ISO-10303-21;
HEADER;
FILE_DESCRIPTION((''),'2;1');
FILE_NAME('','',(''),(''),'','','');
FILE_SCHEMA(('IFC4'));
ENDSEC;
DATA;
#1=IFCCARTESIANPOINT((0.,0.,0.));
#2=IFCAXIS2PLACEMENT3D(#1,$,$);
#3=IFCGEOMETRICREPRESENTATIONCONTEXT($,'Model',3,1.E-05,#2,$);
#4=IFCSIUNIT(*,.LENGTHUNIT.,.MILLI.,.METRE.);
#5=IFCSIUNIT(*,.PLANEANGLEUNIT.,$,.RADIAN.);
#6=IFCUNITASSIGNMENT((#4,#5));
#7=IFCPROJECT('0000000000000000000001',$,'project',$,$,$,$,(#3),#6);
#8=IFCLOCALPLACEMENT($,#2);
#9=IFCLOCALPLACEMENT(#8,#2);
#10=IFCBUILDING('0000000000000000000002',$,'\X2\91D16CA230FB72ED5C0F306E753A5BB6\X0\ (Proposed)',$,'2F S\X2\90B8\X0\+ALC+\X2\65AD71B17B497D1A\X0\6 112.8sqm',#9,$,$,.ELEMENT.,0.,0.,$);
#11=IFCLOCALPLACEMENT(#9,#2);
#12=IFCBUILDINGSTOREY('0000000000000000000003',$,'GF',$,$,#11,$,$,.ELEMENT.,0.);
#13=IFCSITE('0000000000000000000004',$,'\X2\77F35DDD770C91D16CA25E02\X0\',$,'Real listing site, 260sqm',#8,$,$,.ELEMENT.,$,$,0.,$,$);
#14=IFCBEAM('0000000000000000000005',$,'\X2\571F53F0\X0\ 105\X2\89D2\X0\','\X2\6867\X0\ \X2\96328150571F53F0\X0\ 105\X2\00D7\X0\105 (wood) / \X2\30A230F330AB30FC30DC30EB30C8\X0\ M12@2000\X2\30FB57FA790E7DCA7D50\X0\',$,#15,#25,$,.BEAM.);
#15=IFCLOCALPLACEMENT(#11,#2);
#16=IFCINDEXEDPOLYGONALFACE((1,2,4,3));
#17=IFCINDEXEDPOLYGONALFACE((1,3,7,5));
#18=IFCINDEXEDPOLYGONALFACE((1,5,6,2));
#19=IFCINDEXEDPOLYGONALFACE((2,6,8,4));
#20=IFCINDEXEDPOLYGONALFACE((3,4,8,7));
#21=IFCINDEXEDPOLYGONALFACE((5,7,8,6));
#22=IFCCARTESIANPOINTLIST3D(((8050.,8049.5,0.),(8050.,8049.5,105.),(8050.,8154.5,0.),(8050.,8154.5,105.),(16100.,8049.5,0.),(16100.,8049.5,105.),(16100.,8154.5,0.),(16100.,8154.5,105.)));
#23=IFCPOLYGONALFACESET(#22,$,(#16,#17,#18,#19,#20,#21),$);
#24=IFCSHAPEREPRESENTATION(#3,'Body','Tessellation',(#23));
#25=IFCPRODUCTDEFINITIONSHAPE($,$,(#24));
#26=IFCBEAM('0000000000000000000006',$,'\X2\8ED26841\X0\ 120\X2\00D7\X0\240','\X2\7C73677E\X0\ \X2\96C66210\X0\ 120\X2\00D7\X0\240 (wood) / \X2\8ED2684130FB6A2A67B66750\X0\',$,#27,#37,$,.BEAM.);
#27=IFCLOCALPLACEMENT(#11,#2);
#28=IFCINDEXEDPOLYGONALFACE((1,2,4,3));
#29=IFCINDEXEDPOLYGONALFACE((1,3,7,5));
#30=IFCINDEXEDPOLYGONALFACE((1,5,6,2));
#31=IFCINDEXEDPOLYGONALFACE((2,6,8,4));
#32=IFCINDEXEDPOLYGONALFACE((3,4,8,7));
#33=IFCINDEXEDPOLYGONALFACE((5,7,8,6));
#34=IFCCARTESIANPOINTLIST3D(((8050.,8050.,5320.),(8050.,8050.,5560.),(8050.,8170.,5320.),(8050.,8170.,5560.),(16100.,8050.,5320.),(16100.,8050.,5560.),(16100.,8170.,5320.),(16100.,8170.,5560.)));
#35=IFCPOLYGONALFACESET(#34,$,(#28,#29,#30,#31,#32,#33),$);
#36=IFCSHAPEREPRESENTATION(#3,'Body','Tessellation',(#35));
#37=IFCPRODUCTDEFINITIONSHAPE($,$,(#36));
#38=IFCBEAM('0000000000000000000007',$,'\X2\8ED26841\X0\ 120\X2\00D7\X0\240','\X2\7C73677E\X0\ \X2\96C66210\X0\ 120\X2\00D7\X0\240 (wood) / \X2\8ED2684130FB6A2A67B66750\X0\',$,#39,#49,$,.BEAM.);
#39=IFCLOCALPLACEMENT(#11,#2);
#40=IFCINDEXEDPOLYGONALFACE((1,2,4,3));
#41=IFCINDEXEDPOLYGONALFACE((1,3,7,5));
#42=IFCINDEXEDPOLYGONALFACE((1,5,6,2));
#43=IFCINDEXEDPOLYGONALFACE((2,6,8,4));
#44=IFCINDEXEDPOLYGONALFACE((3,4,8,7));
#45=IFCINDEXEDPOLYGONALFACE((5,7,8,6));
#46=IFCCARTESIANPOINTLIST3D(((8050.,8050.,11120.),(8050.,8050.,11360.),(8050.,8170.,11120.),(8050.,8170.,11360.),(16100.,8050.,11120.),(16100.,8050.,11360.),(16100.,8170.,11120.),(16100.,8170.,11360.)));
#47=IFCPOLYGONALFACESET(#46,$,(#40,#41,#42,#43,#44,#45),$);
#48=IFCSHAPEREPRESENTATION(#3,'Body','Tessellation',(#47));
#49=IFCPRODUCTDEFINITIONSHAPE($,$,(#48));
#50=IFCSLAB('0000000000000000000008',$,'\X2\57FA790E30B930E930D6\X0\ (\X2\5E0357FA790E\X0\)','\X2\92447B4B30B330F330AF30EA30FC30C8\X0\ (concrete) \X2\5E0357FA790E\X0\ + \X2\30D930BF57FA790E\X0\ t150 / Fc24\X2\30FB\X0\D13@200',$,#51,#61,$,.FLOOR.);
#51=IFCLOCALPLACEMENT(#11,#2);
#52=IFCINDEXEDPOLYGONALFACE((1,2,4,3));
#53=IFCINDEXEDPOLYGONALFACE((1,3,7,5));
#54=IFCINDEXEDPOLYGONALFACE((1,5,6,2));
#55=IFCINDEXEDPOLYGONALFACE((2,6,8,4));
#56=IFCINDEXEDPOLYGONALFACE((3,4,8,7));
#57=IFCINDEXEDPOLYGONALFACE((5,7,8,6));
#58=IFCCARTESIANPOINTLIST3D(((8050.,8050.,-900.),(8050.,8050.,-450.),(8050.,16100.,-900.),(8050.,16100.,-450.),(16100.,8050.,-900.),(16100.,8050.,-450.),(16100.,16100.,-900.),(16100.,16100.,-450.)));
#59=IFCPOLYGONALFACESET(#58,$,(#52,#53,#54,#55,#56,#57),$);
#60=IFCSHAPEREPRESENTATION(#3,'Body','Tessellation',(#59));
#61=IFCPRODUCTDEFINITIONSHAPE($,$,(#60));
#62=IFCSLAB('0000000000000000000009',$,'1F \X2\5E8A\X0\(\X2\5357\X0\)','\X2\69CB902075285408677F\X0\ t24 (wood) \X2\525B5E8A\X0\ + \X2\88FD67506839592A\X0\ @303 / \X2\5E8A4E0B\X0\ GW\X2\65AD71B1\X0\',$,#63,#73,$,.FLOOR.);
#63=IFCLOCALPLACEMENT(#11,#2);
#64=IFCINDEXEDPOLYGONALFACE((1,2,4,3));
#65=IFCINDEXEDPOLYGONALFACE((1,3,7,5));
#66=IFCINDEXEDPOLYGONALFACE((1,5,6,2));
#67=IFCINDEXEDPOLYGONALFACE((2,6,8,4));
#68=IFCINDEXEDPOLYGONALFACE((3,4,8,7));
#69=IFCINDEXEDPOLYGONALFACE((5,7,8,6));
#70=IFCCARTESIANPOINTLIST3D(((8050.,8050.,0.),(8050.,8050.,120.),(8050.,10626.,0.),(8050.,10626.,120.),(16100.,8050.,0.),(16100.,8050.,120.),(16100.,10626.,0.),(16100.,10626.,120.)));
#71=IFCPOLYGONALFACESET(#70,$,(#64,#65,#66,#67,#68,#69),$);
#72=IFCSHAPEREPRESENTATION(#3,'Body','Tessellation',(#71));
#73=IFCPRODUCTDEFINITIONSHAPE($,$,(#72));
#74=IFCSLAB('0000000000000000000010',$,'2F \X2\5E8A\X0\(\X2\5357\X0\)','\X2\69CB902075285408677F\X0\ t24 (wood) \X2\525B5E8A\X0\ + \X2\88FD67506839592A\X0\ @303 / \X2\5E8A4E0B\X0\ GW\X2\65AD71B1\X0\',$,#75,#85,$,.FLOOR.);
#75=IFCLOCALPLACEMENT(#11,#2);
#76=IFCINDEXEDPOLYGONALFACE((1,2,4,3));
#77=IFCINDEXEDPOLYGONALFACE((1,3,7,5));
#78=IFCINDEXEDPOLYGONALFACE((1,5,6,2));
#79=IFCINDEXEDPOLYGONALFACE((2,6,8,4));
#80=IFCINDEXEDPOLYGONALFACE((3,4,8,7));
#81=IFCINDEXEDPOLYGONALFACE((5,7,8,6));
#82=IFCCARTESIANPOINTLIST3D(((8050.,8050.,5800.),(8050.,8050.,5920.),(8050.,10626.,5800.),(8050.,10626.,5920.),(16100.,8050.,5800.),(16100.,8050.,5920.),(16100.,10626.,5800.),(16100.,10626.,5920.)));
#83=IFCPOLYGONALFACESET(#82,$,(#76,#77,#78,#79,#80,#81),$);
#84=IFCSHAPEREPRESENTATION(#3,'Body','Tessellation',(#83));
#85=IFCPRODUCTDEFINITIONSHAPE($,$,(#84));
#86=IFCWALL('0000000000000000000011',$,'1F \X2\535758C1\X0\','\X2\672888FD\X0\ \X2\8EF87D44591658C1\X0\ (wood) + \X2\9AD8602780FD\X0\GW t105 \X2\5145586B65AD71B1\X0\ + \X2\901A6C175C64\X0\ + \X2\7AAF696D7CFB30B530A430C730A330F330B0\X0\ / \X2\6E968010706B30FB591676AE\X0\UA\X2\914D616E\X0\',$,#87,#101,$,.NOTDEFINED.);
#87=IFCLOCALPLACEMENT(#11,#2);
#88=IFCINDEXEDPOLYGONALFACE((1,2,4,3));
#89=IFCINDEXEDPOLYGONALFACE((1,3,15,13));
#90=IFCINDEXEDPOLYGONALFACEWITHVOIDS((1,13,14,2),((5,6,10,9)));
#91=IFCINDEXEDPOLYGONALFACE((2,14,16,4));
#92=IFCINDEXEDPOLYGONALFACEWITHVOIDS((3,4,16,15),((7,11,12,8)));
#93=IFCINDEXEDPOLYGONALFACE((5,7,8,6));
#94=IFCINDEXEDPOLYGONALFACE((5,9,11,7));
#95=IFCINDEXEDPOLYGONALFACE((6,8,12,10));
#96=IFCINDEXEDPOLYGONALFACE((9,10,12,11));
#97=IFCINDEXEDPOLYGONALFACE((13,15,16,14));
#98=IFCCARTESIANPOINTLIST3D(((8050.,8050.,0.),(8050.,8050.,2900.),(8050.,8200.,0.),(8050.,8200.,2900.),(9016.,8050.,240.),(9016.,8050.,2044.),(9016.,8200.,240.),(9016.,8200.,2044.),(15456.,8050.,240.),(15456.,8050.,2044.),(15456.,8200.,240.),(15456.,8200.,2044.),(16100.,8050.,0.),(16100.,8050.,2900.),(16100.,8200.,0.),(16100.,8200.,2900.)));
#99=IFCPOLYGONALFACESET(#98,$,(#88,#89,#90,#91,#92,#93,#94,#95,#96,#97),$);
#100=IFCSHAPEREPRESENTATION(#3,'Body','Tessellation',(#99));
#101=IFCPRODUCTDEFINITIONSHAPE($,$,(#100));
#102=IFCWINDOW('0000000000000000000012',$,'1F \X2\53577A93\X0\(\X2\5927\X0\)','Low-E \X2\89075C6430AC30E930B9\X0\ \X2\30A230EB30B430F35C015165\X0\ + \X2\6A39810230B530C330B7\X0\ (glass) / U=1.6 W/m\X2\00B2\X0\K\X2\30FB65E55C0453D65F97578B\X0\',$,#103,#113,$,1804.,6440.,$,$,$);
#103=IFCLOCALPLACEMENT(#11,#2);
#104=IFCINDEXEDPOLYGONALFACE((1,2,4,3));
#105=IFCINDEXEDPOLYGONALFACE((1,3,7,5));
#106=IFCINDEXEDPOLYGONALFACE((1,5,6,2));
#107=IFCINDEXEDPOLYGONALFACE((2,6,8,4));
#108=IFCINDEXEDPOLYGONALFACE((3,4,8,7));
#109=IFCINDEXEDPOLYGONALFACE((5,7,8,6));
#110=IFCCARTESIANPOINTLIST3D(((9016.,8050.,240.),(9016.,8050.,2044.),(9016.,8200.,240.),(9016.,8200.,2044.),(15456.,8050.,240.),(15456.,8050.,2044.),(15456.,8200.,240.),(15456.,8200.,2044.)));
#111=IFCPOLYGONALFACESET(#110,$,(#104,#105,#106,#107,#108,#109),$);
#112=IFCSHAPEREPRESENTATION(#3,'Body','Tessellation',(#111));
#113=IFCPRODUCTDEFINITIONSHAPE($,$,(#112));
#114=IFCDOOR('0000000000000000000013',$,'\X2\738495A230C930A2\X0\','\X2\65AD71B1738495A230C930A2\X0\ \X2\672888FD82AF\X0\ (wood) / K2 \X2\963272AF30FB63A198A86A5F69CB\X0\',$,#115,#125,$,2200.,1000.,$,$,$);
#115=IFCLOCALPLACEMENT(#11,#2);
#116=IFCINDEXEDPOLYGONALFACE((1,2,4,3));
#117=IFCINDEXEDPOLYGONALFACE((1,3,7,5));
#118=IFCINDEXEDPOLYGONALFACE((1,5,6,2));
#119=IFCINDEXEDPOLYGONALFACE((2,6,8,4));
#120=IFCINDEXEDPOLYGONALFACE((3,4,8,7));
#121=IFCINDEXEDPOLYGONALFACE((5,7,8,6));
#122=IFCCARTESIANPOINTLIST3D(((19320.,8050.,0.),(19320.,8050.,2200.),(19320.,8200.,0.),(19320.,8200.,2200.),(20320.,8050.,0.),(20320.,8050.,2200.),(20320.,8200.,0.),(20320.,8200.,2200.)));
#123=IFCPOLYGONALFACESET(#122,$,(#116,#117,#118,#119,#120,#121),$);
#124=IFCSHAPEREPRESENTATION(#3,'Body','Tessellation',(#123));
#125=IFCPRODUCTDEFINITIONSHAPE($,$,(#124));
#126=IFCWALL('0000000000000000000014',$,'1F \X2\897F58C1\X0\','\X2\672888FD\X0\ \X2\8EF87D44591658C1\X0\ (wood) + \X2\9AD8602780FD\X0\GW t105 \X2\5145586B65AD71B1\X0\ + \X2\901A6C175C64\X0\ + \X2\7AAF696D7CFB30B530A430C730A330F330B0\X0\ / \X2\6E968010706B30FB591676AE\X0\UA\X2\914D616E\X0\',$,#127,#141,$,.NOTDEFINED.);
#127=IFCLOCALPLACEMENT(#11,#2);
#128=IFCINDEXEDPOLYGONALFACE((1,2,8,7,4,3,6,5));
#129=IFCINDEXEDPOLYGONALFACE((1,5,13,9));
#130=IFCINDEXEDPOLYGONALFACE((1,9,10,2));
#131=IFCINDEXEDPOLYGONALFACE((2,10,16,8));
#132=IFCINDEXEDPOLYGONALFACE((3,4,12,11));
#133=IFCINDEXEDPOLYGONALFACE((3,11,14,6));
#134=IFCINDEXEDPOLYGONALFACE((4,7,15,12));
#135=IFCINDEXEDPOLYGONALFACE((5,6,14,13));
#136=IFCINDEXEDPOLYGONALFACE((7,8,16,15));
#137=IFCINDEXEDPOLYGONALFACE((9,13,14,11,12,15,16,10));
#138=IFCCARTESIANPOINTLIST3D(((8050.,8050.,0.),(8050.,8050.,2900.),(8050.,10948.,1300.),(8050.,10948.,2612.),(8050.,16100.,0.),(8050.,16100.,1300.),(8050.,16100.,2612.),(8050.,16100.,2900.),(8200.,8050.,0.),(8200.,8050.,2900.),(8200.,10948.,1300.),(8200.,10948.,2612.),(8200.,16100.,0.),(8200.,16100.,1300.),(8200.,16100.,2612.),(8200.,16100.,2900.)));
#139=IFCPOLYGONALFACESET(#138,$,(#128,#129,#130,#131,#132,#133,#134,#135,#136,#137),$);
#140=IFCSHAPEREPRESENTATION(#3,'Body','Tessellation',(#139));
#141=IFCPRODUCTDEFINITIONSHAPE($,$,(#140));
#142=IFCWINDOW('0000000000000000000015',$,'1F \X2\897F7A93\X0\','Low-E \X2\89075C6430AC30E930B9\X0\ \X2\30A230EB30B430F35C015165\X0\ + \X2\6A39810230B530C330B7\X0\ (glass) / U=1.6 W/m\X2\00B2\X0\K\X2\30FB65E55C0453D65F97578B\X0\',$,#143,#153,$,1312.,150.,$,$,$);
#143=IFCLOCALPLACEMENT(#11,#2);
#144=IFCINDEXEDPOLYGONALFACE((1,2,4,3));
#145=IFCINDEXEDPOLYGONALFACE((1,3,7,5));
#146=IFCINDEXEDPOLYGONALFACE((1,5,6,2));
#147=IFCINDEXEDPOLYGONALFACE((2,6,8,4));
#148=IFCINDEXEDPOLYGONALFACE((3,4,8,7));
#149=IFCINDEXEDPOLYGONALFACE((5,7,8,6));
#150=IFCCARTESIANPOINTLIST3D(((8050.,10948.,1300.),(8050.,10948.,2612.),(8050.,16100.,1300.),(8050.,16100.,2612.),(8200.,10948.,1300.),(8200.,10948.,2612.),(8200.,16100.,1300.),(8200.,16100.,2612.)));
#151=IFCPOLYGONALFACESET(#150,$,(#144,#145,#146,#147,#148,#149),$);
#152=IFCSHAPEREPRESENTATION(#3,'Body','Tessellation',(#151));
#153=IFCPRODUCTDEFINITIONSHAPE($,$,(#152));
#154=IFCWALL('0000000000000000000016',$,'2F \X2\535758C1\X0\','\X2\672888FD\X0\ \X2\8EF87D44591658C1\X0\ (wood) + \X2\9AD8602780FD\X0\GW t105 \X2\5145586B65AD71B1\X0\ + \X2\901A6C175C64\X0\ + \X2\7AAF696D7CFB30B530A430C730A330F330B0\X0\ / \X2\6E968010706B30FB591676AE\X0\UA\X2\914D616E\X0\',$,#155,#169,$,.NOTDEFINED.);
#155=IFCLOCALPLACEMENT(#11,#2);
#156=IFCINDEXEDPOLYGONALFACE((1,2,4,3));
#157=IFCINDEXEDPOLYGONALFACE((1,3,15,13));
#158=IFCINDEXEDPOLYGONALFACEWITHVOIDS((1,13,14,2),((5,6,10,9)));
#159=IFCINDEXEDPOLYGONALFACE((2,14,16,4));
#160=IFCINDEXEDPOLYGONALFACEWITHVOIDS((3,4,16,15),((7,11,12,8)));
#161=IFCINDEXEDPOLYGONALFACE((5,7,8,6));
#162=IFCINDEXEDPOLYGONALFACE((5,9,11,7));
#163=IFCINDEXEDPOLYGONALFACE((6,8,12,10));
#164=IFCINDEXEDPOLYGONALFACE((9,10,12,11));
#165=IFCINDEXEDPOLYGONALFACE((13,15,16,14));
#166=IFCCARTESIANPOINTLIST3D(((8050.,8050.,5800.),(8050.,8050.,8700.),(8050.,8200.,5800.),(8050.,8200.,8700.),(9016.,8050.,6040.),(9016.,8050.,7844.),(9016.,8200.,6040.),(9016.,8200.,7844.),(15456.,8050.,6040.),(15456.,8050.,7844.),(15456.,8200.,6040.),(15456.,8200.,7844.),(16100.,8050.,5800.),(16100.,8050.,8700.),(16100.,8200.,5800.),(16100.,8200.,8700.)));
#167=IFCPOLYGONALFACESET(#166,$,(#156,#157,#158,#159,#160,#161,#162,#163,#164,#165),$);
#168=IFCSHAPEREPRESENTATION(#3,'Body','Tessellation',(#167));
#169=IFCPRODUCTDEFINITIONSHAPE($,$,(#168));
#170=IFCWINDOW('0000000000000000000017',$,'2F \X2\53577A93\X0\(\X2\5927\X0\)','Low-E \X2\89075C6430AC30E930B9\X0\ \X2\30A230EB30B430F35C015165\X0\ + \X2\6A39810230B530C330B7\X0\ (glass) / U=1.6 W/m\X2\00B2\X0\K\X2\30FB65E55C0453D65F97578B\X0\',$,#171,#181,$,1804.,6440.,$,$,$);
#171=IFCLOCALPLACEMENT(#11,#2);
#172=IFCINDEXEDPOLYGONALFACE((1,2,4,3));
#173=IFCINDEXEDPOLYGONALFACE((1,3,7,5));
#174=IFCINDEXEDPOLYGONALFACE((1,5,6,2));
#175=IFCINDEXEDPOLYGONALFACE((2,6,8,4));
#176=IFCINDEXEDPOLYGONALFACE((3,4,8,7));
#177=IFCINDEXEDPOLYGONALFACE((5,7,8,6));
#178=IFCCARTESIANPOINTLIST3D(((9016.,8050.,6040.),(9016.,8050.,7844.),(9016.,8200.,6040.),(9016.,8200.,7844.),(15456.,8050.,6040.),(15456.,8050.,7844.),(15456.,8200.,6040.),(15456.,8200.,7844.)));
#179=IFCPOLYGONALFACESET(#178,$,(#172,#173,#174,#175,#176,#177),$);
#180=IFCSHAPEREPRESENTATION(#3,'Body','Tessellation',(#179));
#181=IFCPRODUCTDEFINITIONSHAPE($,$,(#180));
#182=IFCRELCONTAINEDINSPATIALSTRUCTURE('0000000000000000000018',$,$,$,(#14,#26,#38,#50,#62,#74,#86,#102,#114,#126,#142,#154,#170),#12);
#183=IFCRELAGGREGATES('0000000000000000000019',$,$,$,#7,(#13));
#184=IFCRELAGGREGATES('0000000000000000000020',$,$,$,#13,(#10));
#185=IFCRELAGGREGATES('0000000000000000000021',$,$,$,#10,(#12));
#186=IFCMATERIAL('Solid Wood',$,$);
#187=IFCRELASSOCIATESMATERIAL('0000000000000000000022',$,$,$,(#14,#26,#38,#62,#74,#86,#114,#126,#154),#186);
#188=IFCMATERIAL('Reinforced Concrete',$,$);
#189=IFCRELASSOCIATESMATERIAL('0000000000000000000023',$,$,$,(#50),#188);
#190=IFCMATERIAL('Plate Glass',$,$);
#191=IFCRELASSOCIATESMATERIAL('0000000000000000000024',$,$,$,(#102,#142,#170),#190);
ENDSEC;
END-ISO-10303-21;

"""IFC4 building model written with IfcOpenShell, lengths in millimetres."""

from ifc_helpers import new_model, si_unit, frame, frame_2d, origin, place, context, project, spatial, rectangle, extrude, material, element, fill, save


model = new_model("IFC4")

# Units and contexts
model_context = context("Model", 3, precision=1e-05, world=origin())
ifc_project = project(units=[si_unit("LENGTHUNIT", "METRE", prefix="MILLI"), si_unit("PLANEANGLEUNIT", "RADIAN")], contexts=[model_context])

# Site, building, storey
site_placement = place(None, origin())
site = spatial("IfcSite", under=ifc_project, at=site_placement, Name="石川県金沢市", ObjectType="Real listing site, 260sqm", CompositionType="ELEMENT", RefElevation=0.0)
building_placement = place(site_placement, origin())
building = spatial("IfcBuilding", under=site, at=building_placement, Name="金沢・狭小の町家 (Proposed)", ObjectType="2F S邸+ALC+断熱等級6 112.8sqm", CompositionType="ELEMENT", ElevationOfRefHeight=0.0, ElevationOfTerrain=0.0)
storey_placement = place(building_placement, origin())
storey = spatial("IfcBuildingStorey", under=building, at=storey_placement, Name="GF", CompositionType="ELEMENT", Elevation=0.0)

# Shared definitions
ifc_material_1 = material(Name="Solid Wood")

# Beams
beam_1_placement = place(storey_placement, frame((4025.0, 4025.0, 0.0)))
element("IfcBeam", 1, at=beam_1_placement, inside=storey, material=ifc_material_1, Name="土台 105角", Description="桧 防腐土台 105×105 (wood) / アンカーボルト M12@2000・基礎緊結", PredefinedType="BEAM", context=model_context, shape_type="SweptSolid", body=[
    extrude(rectangle(XDim=8050.0, YDim=105.0, at=frame_2d((4025.0, 52.0))), frame((4025.0, 4025.0, 0.0)), (0.0, 0.0, 1.0), 105.0),
])
beam_2_placement = place(storey_placement, frame((4025.0, 4025.0, 2660.0)))
element("IfcBeam", 2, at=beam_2_placement, inside=storey, material=ifc_material_1, Name="軒桁 120×240", Description="米松 集成 120×240 (wood) / 軒桁・横架材", PredefinedType="BEAM", context=model_context, shape_type="SweptSolid", body=[
    extrude(rectangle(XDim=8050.0, YDim=120.0, at=frame_2d((4025.0, 60.0))), frame((4025.0, 4025.0, 2660.0)), (0.0, 0.0, 1.0), 240.0),
])
beam_3_placement = place(storey_placement, frame((4025.0, 4025.0, 5560.0)))
element("IfcBeam", 3, at=beam_3_placement, inside=storey, material=ifc_material_1, Name="軒桁 120×240", Description="米松 集成 120×240 (wood) / 軒桁・横架材", PredefinedType="BEAM", context=model_context, shape_type="SweptSolid", body=[
    extrude(rectangle(XDim=8050.0, YDim=120.0, at=frame_2d((4025.0, 60.0))), frame((4025.0, 4025.0, 5560.0)), (0.0, 0.0, 1.0), 240.0),
])

# Slabs
ifc_material_2 = material(Name="Reinforced Concrete")
slab_1_placement = place(storey_placement, frame((4025.0, 4025.0, -450.0)))
element("IfcSlab", 4, at=slab_1_placement, inside=storey, material=ifc_material_2, Name="基礎スラブ (布基礎)", Description="鉄筋コンクリート (concrete) 布基礎 + ベタ基礎 t150 / Fc24・D13@200", PredefinedType="FLOOR", context=model_context, shape_type="SweptSolid", body=[
    extrude(rectangle(XDim=8050.0, YDim=8050.0, at=frame_2d((4025.0, 4025.0))), frame((4025.0, 4025.0, -450.0)), (0.0, 0.0, 1.0), 450.0),
])
slab_2_placement = place(storey_placement, frame((4025.0, 4025.0, 0.0)))
element("IfcSlab", 5, at=slab_2_placement, inside=storey, material=ifc_material_1, Name="1F 床(南)", Description="構造用合板 t24 (wood) 剛床 + 製材根太 @303 / 床下 GW断熱", PredefinedType="FLOOR", context=model_context, shape_type="SweptSolid", body=[
    extrude(rectangle(XDim=8050.0, YDim=2576.0, at=frame_2d((4025.0, 1288.0))), frame((4025.0, 4025.0, 0.0)), (0.0, 0.0, 1.0), 120.0),
])
slab_3_placement = place(storey_placement, frame((4025.0, 4025.0, 2900.0)))
element("IfcSlab", 6, at=slab_3_placement, inside=storey, material=ifc_material_1, Name="2F 床(南)", Description="構造用合板 t24 (wood) 剛床 + 製材根太 @303 / 床下 GW断熱", PredefinedType="FLOOR", context=model_context, shape_type="SweptSolid", body=[
    extrude(rectangle(XDim=8050.0, YDim=2576.0, at=frame_2d((4025.0, 1288.0))), frame((4025.0, 4025.0, 2900.0)), (0.0, 0.0, 1.0), 120.0),
])

# Wall, openings, window, door
wall_1_placement = place(storey_placement, frame((4025.0, 4025.0, 0.0)))
wall_1 = element("IfcWall", 7, at=wall_1_placement, inside=storey, material=ifc_material_1, Name="1F 南壁", Description="木製 軸組外壁 (wood) + 高性能GW t105 充填断熱 + 通気層 + 窯業系サイディング / 準耐火・外皮UA配慮", PredefinedType="NOTDEFINED", context=model_context, shape_type="SweptSolid", body=[
    extrude(rectangle(XDim=8050.0, YDim=150.0, at=frame_2d((4025.0, 75.0))), frame((4025.0, 4025.0, 0.0)), (0.0, 0.0, 1.0), 2900.0),
])
opening_1_placement = place(storey_placement, frame((4508.0, 4025.0, 120.0)))
opening_1 = element("IfcOpeningElement", 8, at=opening_1_placement, cuts=wall_1, PredefinedType="NOTDEFINED", context=model_context, shape_type="SweptSolid", body=[
    extrude(rectangle(XDim=6440.0, YDim=150.0, at=frame_2d((3220.0, 75.0))), frame((4508.0, 4025.0, 120.0)), (0.0, 0.0, 1.0), 1804.0),
])
opening_2_placement = place(storey_placement, frame((9660.0, 4025.0, 0.0)))
opening_2 = element("IfcOpeningElement", 9, at=opening_2_placement, cuts=wall_1, PredefinedType="NOTDEFINED", context=model_context, shape_type="SweptSolid", body=[
    extrude(rectangle(XDim=1000.0, YDim=150.0, at=frame_2d((500.0, 75.0))), frame((9660.0, 4025.0, 0.0)), (0.0, 0.0, 1.0), 2200.0),
])
ifc_material_3 = material(Name="Plate Glass")
window_1_placement = place(storey_placement, frame((4508.0, 4025.0, 120.0)))
window_1 = element("IfcWindow", 10, at=window_1_placement, inside=storey, material=ifc_material_3, Name="1F 南窓(大)", Description="Low-E 複層ガラス アルゴン封入 + 樹脂サッシ (glass) / U=1.6 W/m²K・日射取得型", OverallHeight=1804.0, OverallWidth=6440.0, context=model_context, shape_type="SweptSolid", body=[
    extrude(rectangle(XDim=6440.0, YDim=150.0, at=frame_2d((3220.0, 75.0))), frame((4508.0, 4025.0, 120.0)), (0.0, 0.0, 1.0), 1804.0),
])
fill(opening_1, window_1)
door_placement = place(storey_placement, frame((9660.0, 4025.0, 0.0)))
door = element("IfcDoor", 11, at=door_placement, inside=storey, material=ifc_material_1, Name="玄関ドア", Description="断熱玄関ドア 木製芯 (wood) / K2 防犯・採風機構", OverallHeight=2200.0, OverallWidth=1000.0, context=model_context, shape_type="SweptSolid", body=[
    extrude(rectangle(XDim=1000.0, YDim=150.0, at=frame_2d((500.0, 75.0))), frame((9660.0, 4025.0, 0.0)), (0.0, 0.0, 1.0), 2200.0),
])
fill(opening_2, door)

# Walls, openings, windows
wall_2_placement = place(storey_placement, frame((4025.0, 4025.0, 0.0)))
wall_2 = element("IfcWall", 12, at=wall_2_placement, inside=storey, material=ifc_material_1, Name="1F 西壁", Description="木製 軸組外壁 (wood) + 高性能GW t105 充填断熱 + 通気層 + 窯業系サイディング / 準耐火・外皮UA配慮", PredefinedType="NOTDEFINED", context=model_context, shape_type="SweptSolid", body=[
    extrude(rectangle(XDim=150.0, YDim=8050.0, at=frame_2d((75.0, 4025.0))), frame((4025.0, 4025.0, 0.0)), (0.0, 0.0, 1.0), 2900.0),
])
opening_3_placement = place(storey_placement, frame((4025.0, 5474.0, 650.0)))
opening_3 = element("IfcOpeningElement", 13, at=opening_3_placement, cuts=wall_2, PredefinedType="NOTDEFINED", context=model_context, shape_type="SweptSolid", body=[
    extrude(rectangle(XDim=150.0, YDim=5152.0, at=frame_2d((75.0, 2576.0))), frame((4025.0, 5474.0, 650.0)), (0.0, 0.0, 1.0), 1312.0),
])
window_2_placement = place(storey_placement, frame((4025.0, 5474.0, 650.0)))
window_2 = element("IfcWindow", 14, at=window_2_placement, inside=storey, material=ifc_material_3, Name="1F 西窓", Description="Low-E 複層ガラス アルゴン封入 + 樹脂サッシ (glass) / U=1.6 W/m²K・日射取得型", OverallHeight=1312.0, OverallWidth=150.0, context=model_context, shape_type="SweptSolid", body=[
    extrude(rectangle(XDim=150.0, YDim=5152.0, at=frame_2d((75.0, 2576.0))), frame((4025.0, 5474.0, 650.0)), (0.0, 0.0, 1.0), 1312.0),
])
fill(opening_3, window_2)
wall_3_placement = place(storey_placement, frame((4025.0, 4025.0, 2900.0)))
wall_3 = element("IfcWall", 15, at=wall_3_placement, inside=storey, material=ifc_material_1, Name="2F 南壁", Description="木製 軸組外壁 (wood) + 高性能GW t105 充填断熱 + 通気層 + 窯業系サイディング / 準耐火・外皮UA配慮", PredefinedType="NOTDEFINED", context=model_context, shape_type="SweptSolid", body=[
    extrude(rectangle(XDim=8050.0, YDim=150.0, at=frame_2d((4025.0, 75.0))), frame((4025.0, 4025.0, 2900.0)), (0.0, 0.0, 1.0), 2900.0),
])
opening_4_placement = place(storey_placement, frame((4508.0, 4025.0, 3020.0)))
opening_4 = element("IfcOpeningElement", 16, at=opening_4_placement, cuts=wall_3, PredefinedType="NOTDEFINED", context=model_context, shape_type="SweptSolid", body=[
    extrude(rectangle(XDim=6440.0, YDim=150.0, at=frame_2d((3220.0, 75.0))), frame((4508.0, 4025.0, 3020.0)), (0.0, 0.0, 1.0), 1804.0),
])
window_3_placement = place(storey_placement, frame((4508.0, 4025.0, 3020.0)))
window_3 = element("IfcWindow", 17, at=window_3_placement, inside=storey, material=ifc_material_3, Name="2F 南窓(大)", Description="Low-E 複層ガラス アルゴン封入 + 樹脂サッシ (glass) / U=1.6 W/m²K・日射取得型", OverallHeight=1804.0, OverallWidth=6440.0, context=model_context, shape_type="SweptSolid", body=[
    extrude(rectangle(XDim=6440.0, YDim=150.0, at=frame_2d((3220.0, 75.0))), frame((4508.0, 4025.0, 3020.0)), (0.0, 0.0, 1.0), 1804.0),
])
fill(opening_4, window_3)

save(model, "model.ifc")
